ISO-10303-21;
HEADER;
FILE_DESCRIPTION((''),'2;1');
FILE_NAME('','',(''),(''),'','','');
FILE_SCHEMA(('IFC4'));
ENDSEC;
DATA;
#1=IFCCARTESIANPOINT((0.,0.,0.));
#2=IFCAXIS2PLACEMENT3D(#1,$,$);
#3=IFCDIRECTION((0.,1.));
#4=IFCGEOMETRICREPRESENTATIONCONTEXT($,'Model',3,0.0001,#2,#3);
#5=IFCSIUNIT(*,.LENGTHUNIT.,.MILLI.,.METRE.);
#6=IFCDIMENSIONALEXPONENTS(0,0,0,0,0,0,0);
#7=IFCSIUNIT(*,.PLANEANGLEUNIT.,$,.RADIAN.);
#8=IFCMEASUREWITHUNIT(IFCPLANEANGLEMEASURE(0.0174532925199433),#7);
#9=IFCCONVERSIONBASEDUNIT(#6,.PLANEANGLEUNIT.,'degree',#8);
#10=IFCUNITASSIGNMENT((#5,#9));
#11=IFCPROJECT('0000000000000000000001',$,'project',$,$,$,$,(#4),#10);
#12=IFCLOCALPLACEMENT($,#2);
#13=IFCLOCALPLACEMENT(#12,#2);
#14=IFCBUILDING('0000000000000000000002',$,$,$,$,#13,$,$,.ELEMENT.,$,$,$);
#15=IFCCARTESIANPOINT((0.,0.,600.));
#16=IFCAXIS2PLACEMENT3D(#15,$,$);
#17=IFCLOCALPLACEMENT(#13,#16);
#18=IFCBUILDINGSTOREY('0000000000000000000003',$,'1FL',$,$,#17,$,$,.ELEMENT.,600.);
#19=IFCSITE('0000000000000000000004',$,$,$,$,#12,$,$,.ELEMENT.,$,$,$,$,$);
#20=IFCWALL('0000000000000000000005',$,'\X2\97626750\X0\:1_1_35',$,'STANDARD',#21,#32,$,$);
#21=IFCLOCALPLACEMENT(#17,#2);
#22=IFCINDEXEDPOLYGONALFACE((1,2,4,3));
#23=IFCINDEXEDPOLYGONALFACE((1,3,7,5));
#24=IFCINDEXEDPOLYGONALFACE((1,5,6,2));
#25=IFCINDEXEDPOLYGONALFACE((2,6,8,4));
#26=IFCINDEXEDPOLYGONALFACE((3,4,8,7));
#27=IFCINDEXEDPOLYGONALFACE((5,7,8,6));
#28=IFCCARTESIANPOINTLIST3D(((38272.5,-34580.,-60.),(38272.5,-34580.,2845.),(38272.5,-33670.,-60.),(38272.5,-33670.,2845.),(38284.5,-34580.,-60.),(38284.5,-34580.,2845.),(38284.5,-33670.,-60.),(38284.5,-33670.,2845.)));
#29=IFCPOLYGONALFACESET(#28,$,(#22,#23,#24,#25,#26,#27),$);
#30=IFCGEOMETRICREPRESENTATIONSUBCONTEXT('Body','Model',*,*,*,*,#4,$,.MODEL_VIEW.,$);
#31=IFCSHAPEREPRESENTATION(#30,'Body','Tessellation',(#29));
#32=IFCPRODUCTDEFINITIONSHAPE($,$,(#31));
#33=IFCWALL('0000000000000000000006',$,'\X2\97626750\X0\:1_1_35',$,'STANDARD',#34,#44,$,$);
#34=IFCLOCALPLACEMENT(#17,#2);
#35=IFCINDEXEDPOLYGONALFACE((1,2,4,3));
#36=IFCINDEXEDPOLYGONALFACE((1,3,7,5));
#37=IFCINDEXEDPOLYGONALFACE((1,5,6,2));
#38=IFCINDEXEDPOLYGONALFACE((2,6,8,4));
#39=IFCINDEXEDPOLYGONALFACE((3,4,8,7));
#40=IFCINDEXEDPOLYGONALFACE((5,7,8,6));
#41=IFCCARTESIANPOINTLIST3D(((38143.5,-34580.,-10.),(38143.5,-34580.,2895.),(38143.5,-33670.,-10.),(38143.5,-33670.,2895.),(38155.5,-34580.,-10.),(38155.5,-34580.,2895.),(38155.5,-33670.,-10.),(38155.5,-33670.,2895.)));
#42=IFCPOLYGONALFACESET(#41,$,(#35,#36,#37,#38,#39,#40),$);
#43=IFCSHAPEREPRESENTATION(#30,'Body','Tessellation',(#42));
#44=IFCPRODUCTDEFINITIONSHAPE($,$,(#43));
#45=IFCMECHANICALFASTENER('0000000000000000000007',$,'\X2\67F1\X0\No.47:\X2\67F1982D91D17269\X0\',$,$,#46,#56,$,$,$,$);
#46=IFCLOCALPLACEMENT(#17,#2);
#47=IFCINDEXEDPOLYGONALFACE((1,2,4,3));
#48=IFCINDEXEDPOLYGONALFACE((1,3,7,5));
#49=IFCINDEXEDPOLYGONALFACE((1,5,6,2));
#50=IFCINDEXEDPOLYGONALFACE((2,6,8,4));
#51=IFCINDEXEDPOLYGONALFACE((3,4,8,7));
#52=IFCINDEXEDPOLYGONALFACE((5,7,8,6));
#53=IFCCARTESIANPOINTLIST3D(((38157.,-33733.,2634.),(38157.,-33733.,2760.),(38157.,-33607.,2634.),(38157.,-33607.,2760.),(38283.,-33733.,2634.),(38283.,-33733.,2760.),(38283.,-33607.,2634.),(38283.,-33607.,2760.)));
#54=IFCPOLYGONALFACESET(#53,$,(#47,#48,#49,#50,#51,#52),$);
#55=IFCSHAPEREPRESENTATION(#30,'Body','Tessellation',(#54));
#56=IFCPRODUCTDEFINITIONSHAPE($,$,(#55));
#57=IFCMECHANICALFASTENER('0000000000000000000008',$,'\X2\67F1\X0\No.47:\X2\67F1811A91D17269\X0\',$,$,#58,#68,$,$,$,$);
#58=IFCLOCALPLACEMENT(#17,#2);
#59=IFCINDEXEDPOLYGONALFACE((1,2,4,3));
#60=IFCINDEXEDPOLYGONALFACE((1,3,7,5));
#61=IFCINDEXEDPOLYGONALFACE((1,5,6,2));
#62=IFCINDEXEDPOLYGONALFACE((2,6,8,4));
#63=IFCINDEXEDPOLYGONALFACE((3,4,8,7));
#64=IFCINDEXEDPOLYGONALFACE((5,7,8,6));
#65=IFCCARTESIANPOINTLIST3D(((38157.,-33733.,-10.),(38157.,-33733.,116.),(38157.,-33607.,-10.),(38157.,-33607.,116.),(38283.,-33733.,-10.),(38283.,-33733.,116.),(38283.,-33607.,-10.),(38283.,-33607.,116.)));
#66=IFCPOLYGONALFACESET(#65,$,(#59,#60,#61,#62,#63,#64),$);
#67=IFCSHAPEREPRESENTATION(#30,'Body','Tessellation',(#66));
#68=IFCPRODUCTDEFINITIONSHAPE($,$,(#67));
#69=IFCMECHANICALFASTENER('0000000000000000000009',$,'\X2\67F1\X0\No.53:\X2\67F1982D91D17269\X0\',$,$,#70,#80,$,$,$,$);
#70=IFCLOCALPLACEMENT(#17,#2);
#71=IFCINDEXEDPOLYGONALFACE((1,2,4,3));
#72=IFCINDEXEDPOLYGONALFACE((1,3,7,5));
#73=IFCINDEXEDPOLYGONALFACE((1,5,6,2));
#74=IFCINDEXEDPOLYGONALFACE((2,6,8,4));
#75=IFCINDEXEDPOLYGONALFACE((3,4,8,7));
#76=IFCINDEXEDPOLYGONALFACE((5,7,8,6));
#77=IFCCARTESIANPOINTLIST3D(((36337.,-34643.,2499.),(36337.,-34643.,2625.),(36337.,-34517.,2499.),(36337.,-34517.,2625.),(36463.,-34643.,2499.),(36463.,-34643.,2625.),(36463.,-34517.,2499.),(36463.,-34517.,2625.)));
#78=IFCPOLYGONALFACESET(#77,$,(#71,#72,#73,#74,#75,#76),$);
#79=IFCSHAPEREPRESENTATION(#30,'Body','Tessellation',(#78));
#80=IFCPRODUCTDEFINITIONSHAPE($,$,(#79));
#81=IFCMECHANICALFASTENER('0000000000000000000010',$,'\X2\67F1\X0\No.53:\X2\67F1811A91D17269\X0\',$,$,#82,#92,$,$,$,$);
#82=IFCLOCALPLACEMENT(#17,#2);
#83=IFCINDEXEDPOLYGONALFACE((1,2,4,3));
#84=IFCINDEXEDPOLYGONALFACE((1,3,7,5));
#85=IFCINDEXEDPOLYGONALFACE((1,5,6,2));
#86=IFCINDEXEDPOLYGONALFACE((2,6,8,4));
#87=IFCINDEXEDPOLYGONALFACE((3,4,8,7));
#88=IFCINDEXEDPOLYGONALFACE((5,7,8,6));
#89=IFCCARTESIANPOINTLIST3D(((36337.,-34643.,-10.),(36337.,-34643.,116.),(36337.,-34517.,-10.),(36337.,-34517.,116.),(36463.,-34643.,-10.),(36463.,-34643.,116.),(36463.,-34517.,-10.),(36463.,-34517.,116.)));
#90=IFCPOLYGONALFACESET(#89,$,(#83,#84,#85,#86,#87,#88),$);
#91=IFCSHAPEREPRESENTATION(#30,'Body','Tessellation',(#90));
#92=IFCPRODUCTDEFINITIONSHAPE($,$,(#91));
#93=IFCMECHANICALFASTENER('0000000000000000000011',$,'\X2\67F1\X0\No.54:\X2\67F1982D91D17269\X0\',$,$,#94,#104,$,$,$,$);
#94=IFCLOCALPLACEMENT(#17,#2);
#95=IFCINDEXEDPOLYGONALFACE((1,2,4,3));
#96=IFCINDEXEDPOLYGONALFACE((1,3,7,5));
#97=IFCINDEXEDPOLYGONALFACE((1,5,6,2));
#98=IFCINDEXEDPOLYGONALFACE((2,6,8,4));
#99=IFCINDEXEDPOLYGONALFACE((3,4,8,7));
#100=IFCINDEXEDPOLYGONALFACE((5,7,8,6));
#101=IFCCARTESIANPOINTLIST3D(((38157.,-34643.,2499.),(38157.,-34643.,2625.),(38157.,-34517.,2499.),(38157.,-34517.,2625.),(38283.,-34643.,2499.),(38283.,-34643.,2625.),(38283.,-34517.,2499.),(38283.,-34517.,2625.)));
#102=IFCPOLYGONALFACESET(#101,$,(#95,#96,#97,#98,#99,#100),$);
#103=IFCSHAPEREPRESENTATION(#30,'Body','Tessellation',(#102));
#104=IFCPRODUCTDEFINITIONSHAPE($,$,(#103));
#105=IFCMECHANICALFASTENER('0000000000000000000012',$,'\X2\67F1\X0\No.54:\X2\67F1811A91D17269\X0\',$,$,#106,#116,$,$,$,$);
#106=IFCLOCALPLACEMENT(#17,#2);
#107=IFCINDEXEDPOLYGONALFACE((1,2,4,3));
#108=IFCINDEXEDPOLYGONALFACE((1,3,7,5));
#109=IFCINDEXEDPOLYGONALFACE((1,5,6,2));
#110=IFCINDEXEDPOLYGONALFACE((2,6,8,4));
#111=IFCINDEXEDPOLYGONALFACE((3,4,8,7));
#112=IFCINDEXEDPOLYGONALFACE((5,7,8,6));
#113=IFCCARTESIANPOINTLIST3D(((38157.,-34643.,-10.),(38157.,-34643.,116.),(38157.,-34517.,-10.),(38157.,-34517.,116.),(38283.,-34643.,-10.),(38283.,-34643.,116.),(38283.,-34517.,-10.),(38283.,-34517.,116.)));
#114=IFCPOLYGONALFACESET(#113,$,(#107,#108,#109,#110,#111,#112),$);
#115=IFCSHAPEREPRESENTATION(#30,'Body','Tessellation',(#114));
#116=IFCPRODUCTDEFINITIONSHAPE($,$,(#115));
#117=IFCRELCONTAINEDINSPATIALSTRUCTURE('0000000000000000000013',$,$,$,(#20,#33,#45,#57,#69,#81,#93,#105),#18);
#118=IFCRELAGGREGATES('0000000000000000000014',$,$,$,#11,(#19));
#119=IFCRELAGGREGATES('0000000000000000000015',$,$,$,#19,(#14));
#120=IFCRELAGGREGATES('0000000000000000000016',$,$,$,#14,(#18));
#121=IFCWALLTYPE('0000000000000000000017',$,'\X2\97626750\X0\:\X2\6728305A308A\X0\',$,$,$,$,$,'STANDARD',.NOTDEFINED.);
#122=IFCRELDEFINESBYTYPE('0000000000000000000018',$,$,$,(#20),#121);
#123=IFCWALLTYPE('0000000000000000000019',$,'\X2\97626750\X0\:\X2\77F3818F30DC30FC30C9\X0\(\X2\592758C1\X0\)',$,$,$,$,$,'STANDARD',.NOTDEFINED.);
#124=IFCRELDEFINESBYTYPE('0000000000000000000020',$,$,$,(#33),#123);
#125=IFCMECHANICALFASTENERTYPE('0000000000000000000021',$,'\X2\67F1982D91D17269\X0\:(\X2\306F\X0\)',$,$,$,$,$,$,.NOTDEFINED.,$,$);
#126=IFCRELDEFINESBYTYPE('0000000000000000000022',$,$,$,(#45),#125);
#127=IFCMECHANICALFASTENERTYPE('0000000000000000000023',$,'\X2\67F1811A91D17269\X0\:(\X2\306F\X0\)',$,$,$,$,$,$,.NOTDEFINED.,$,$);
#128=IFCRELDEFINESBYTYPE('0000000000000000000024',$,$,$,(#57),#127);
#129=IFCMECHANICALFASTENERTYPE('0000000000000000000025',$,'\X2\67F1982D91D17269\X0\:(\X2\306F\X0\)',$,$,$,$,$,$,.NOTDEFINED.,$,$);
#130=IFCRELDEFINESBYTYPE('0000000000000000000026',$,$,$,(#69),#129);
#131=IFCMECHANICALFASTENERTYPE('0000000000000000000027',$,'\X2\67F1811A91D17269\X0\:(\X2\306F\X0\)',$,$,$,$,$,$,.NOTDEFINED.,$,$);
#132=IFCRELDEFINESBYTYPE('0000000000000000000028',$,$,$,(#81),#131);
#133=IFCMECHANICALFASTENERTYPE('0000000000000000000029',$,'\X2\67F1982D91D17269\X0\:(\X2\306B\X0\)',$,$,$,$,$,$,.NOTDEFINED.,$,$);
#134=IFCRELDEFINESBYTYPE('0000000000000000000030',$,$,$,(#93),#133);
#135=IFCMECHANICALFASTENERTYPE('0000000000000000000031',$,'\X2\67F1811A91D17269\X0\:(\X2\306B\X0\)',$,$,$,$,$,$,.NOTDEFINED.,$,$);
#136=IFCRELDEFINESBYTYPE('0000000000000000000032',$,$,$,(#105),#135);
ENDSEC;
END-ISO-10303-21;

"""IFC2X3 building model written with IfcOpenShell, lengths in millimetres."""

from ifc_helpers import new_model, entity, si_unit, converted_unit, direction, frame, origin, origin_with_axes, origin_2d, place, context, subcontext, project, spatial, polyline, rectangle, outline, extrude, type_object, element, save


model = new_model("IFC2X3")

# Units and contexts
model_context = context("Model", 3, precision=0.0001, world=origin(), true_north=direction((0.0, 1.0)))
body_context = subcontext(model_context, "Body", "Model", "MODEL_VIEW")
ifc_project = project(units=[si_unit("LENGTHUNIT", "METRE", prefix="MILLI"), converted_unit("PLANEANGLEUNIT", "degree", entity("IfcPlaneAngleMeasure", 0.0174532925199433), si_unit("PLANEANGLEUNIT", "RADIAN"), dimensions=[0, 0, 0, 0, 0, 0, 0])], contexts=[model_context])

# Site, building, storey
site_placement = place(None, origin())
site = spatial("IfcSite", under=ifc_project, at=site_placement, CompositionType="ELEMENT")
building_placement = place(site_placement, origin())
building = spatial("IfcBuilding", under=site, at=building_placement, CompositionType="ELEMENT")
storey_placement = place(building_placement, frame((0.0, 0.0, 600.0)))
storey = spatial("IfcBuildingStorey", under=building, at=storey_placement, Name="1FL", CompositionType="ELEMENT", Elevation=600.0)

# Walls
wall_type_1 = type_object("IfcWallType", Name="面材:木ずり", ElementType="STANDARD", PredefinedType="NOTDEFINED")
wall_1_placement = place(storey_placement, frame((38284.5, -34125.0, -60.0), z_axis=(-1.0, 0.0, 0.0), x_axis=(0.0, -1.0, 0.0)))
element("IfcWall", 1, at=wall_1_placement, inside=storey, type_object=wall_type_1, Name="面材:1_1_35", ObjectType="STANDARD", context=body_context, shape_type="SweptSolid", body=[
    extrude(outline(polyline([(455.0, 0.0, 0.0), (-455.0, 0.0, 0.0), (-455.0, 2905.0, 0.0), (455.0, 2905.0, 0.0), (455.0, 0.0, 0.0)])), origin_with_axes(), (0.0, 0.0, 1.0), 12.0),
])
wall_type_2 = type_object("IfcWallType", Name="面材:石膏ボード(大壁)", ElementType="STANDARD", PredefinedType="NOTDEFINED")
wall_2_placement = place(storey_placement, frame((38155.5, -34125.0, -10.0), z_axis=(-1.0, 0.0, 0.0), x_axis=(0.0, -1.0, 0.0)))
element("IfcWall", 2, at=wall_2_placement, inside=storey, type_object=wall_type_2, Name="面材:1_1_35", ObjectType="STANDARD", context=body_context, shape_type="SweptSolid", body=[
    extrude(outline(polyline([(455.0, 0.0, 0.0), (-455.0, 0.0, 0.0), (-455.0, 2905.0, 0.0), (455.0, 2905.0, 0.0), (455.0, 0.0, 0.0)])), origin_with_axes(), (0.0, 0.0, 1.0), 12.0),
])

# Mechanical fasteners
mechanical_fastener_type_1 = type_object("IfcMechanicalFastenerType", Name="柱頭金物:(は)")
mechanical_fastener_1_placement = place(storey_placement, frame((38220.0, -33670.0, 2634.0)))
element("IfcMechanicalFastener", 3, at=mechanical_fastener_1_placement, inside=storey, type_object=mechanical_fastener_type_1, Name="柱No.47:柱頭金物", context=body_context, shape_type="SweptSolid", body=[
    extrude(rectangle(XDim=126.0, YDim=126.0, at=origin_2d()), origin_with_axes(), (0.0, 0.0, 1.0), 126.0),
])
mechanical_fastener_type_2 = type_object("IfcMechanicalFastenerType", Name="柱脚金物:(は)")
mechanical_fastener_2_placement = place(storey_placement, frame((38220.0, -33670.0, -10.0)))
element("IfcMechanicalFastener", 4, at=mechanical_fastener_2_placement, inside=storey, type_object=mechanical_fastener_type_2, Name="柱No.47:柱脚金物", context=body_context, shape_type="SweptSolid", body=[
    extrude(rectangle(XDim=126.0, YDim=126.0, at=origin_2d()), origin_with_axes(), (0.0, 0.0, 1.0), 126.0),
])
mechanical_fastener_type_3 = type_object("IfcMechanicalFastenerType", Name="柱頭金物:(は)")
mechanical_fastener_3_placement = place(storey_placement, frame((36400.0, -34580.0, 2499.0)))
element("IfcMechanicalFastener", 5, at=mechanical_fastener_3_placement, inside=storey, type_object=mechanical_fastener_type_3, Name="柱No.53:柱頭金物", context=body_context, shape_type="SweptSolid", body=[
    extrude(rectangle(XDim=126.0, YDim=126.0, at=origin_2d()), origin_with_axes(), (0.0, 0.0, 1.0), 126.0),
])
mechanical_fastener_type_4 = type_object("IfcMechanicalFastenerType", Name="柱脚金物:(は)")
mechanical_fastener_4_placement = place(storey_placement, frame((36400.0, -34580.0, -10.0)))
element("IfcMechanicalFastener", 6, at=mechanical_fastener_4_placement, inside=storey, type_object=mechanical_fastener_type_4, Name="柱No.53:柱脚金物", context=body_context, shape_type="SweptSolid", body=[
    extrude(rectangle(XDim=126.0, YDim=126.0, at=origin_2d()), origin_with_axes(), (0.0, 0.0, 1.0), 126.0),
])
mechanical_fastener_type_5 = type_object("IfcMechanicalFastenerType", Name="柱頭金物:(に)")
mechanical_fastener_5_placement = place(storey_placement, frame((38220.0, -34580.0, 2499.0)))
element("IfcMechanicalFastener", 7, at=mechanical_fastener_5_placement, inside=storey, type_object=mechanical_fastener_type_5, Name="柱No.54:柱頭金物", context=body_context, shape_type="SweptSolid", body=[
    extrude(rectangle(XDim=126.0, YDim=126.0, at=origin_2d()), origin_with_axes(), (0.0, 0.0, 1.0), 126.0),
])
mechanical_fastener_type_6 = type_object("IfcMechanicalFastenerType", Name="柱脚金物:(に)")
mechanical_fastener_6_placement = place(storey_placement, frame((38220.0, -34580.0, -10.0)))
element("IfcMechanicalFastener", 8, at=mechanical_fastener_6_placement, inside=storey, type_object=mechanical_fastener_type_6, Name="柱No.54:柱脚金物", context=body_context, shape_type="SweptSolid", body=[
    extrude(rectangle(XDim=126.0, YDim=126.0, at=origin_2d()), origin_with_axes(), (0.0, 0.0, 1.0), 126.0),
])

save(model, "model.ifc")
